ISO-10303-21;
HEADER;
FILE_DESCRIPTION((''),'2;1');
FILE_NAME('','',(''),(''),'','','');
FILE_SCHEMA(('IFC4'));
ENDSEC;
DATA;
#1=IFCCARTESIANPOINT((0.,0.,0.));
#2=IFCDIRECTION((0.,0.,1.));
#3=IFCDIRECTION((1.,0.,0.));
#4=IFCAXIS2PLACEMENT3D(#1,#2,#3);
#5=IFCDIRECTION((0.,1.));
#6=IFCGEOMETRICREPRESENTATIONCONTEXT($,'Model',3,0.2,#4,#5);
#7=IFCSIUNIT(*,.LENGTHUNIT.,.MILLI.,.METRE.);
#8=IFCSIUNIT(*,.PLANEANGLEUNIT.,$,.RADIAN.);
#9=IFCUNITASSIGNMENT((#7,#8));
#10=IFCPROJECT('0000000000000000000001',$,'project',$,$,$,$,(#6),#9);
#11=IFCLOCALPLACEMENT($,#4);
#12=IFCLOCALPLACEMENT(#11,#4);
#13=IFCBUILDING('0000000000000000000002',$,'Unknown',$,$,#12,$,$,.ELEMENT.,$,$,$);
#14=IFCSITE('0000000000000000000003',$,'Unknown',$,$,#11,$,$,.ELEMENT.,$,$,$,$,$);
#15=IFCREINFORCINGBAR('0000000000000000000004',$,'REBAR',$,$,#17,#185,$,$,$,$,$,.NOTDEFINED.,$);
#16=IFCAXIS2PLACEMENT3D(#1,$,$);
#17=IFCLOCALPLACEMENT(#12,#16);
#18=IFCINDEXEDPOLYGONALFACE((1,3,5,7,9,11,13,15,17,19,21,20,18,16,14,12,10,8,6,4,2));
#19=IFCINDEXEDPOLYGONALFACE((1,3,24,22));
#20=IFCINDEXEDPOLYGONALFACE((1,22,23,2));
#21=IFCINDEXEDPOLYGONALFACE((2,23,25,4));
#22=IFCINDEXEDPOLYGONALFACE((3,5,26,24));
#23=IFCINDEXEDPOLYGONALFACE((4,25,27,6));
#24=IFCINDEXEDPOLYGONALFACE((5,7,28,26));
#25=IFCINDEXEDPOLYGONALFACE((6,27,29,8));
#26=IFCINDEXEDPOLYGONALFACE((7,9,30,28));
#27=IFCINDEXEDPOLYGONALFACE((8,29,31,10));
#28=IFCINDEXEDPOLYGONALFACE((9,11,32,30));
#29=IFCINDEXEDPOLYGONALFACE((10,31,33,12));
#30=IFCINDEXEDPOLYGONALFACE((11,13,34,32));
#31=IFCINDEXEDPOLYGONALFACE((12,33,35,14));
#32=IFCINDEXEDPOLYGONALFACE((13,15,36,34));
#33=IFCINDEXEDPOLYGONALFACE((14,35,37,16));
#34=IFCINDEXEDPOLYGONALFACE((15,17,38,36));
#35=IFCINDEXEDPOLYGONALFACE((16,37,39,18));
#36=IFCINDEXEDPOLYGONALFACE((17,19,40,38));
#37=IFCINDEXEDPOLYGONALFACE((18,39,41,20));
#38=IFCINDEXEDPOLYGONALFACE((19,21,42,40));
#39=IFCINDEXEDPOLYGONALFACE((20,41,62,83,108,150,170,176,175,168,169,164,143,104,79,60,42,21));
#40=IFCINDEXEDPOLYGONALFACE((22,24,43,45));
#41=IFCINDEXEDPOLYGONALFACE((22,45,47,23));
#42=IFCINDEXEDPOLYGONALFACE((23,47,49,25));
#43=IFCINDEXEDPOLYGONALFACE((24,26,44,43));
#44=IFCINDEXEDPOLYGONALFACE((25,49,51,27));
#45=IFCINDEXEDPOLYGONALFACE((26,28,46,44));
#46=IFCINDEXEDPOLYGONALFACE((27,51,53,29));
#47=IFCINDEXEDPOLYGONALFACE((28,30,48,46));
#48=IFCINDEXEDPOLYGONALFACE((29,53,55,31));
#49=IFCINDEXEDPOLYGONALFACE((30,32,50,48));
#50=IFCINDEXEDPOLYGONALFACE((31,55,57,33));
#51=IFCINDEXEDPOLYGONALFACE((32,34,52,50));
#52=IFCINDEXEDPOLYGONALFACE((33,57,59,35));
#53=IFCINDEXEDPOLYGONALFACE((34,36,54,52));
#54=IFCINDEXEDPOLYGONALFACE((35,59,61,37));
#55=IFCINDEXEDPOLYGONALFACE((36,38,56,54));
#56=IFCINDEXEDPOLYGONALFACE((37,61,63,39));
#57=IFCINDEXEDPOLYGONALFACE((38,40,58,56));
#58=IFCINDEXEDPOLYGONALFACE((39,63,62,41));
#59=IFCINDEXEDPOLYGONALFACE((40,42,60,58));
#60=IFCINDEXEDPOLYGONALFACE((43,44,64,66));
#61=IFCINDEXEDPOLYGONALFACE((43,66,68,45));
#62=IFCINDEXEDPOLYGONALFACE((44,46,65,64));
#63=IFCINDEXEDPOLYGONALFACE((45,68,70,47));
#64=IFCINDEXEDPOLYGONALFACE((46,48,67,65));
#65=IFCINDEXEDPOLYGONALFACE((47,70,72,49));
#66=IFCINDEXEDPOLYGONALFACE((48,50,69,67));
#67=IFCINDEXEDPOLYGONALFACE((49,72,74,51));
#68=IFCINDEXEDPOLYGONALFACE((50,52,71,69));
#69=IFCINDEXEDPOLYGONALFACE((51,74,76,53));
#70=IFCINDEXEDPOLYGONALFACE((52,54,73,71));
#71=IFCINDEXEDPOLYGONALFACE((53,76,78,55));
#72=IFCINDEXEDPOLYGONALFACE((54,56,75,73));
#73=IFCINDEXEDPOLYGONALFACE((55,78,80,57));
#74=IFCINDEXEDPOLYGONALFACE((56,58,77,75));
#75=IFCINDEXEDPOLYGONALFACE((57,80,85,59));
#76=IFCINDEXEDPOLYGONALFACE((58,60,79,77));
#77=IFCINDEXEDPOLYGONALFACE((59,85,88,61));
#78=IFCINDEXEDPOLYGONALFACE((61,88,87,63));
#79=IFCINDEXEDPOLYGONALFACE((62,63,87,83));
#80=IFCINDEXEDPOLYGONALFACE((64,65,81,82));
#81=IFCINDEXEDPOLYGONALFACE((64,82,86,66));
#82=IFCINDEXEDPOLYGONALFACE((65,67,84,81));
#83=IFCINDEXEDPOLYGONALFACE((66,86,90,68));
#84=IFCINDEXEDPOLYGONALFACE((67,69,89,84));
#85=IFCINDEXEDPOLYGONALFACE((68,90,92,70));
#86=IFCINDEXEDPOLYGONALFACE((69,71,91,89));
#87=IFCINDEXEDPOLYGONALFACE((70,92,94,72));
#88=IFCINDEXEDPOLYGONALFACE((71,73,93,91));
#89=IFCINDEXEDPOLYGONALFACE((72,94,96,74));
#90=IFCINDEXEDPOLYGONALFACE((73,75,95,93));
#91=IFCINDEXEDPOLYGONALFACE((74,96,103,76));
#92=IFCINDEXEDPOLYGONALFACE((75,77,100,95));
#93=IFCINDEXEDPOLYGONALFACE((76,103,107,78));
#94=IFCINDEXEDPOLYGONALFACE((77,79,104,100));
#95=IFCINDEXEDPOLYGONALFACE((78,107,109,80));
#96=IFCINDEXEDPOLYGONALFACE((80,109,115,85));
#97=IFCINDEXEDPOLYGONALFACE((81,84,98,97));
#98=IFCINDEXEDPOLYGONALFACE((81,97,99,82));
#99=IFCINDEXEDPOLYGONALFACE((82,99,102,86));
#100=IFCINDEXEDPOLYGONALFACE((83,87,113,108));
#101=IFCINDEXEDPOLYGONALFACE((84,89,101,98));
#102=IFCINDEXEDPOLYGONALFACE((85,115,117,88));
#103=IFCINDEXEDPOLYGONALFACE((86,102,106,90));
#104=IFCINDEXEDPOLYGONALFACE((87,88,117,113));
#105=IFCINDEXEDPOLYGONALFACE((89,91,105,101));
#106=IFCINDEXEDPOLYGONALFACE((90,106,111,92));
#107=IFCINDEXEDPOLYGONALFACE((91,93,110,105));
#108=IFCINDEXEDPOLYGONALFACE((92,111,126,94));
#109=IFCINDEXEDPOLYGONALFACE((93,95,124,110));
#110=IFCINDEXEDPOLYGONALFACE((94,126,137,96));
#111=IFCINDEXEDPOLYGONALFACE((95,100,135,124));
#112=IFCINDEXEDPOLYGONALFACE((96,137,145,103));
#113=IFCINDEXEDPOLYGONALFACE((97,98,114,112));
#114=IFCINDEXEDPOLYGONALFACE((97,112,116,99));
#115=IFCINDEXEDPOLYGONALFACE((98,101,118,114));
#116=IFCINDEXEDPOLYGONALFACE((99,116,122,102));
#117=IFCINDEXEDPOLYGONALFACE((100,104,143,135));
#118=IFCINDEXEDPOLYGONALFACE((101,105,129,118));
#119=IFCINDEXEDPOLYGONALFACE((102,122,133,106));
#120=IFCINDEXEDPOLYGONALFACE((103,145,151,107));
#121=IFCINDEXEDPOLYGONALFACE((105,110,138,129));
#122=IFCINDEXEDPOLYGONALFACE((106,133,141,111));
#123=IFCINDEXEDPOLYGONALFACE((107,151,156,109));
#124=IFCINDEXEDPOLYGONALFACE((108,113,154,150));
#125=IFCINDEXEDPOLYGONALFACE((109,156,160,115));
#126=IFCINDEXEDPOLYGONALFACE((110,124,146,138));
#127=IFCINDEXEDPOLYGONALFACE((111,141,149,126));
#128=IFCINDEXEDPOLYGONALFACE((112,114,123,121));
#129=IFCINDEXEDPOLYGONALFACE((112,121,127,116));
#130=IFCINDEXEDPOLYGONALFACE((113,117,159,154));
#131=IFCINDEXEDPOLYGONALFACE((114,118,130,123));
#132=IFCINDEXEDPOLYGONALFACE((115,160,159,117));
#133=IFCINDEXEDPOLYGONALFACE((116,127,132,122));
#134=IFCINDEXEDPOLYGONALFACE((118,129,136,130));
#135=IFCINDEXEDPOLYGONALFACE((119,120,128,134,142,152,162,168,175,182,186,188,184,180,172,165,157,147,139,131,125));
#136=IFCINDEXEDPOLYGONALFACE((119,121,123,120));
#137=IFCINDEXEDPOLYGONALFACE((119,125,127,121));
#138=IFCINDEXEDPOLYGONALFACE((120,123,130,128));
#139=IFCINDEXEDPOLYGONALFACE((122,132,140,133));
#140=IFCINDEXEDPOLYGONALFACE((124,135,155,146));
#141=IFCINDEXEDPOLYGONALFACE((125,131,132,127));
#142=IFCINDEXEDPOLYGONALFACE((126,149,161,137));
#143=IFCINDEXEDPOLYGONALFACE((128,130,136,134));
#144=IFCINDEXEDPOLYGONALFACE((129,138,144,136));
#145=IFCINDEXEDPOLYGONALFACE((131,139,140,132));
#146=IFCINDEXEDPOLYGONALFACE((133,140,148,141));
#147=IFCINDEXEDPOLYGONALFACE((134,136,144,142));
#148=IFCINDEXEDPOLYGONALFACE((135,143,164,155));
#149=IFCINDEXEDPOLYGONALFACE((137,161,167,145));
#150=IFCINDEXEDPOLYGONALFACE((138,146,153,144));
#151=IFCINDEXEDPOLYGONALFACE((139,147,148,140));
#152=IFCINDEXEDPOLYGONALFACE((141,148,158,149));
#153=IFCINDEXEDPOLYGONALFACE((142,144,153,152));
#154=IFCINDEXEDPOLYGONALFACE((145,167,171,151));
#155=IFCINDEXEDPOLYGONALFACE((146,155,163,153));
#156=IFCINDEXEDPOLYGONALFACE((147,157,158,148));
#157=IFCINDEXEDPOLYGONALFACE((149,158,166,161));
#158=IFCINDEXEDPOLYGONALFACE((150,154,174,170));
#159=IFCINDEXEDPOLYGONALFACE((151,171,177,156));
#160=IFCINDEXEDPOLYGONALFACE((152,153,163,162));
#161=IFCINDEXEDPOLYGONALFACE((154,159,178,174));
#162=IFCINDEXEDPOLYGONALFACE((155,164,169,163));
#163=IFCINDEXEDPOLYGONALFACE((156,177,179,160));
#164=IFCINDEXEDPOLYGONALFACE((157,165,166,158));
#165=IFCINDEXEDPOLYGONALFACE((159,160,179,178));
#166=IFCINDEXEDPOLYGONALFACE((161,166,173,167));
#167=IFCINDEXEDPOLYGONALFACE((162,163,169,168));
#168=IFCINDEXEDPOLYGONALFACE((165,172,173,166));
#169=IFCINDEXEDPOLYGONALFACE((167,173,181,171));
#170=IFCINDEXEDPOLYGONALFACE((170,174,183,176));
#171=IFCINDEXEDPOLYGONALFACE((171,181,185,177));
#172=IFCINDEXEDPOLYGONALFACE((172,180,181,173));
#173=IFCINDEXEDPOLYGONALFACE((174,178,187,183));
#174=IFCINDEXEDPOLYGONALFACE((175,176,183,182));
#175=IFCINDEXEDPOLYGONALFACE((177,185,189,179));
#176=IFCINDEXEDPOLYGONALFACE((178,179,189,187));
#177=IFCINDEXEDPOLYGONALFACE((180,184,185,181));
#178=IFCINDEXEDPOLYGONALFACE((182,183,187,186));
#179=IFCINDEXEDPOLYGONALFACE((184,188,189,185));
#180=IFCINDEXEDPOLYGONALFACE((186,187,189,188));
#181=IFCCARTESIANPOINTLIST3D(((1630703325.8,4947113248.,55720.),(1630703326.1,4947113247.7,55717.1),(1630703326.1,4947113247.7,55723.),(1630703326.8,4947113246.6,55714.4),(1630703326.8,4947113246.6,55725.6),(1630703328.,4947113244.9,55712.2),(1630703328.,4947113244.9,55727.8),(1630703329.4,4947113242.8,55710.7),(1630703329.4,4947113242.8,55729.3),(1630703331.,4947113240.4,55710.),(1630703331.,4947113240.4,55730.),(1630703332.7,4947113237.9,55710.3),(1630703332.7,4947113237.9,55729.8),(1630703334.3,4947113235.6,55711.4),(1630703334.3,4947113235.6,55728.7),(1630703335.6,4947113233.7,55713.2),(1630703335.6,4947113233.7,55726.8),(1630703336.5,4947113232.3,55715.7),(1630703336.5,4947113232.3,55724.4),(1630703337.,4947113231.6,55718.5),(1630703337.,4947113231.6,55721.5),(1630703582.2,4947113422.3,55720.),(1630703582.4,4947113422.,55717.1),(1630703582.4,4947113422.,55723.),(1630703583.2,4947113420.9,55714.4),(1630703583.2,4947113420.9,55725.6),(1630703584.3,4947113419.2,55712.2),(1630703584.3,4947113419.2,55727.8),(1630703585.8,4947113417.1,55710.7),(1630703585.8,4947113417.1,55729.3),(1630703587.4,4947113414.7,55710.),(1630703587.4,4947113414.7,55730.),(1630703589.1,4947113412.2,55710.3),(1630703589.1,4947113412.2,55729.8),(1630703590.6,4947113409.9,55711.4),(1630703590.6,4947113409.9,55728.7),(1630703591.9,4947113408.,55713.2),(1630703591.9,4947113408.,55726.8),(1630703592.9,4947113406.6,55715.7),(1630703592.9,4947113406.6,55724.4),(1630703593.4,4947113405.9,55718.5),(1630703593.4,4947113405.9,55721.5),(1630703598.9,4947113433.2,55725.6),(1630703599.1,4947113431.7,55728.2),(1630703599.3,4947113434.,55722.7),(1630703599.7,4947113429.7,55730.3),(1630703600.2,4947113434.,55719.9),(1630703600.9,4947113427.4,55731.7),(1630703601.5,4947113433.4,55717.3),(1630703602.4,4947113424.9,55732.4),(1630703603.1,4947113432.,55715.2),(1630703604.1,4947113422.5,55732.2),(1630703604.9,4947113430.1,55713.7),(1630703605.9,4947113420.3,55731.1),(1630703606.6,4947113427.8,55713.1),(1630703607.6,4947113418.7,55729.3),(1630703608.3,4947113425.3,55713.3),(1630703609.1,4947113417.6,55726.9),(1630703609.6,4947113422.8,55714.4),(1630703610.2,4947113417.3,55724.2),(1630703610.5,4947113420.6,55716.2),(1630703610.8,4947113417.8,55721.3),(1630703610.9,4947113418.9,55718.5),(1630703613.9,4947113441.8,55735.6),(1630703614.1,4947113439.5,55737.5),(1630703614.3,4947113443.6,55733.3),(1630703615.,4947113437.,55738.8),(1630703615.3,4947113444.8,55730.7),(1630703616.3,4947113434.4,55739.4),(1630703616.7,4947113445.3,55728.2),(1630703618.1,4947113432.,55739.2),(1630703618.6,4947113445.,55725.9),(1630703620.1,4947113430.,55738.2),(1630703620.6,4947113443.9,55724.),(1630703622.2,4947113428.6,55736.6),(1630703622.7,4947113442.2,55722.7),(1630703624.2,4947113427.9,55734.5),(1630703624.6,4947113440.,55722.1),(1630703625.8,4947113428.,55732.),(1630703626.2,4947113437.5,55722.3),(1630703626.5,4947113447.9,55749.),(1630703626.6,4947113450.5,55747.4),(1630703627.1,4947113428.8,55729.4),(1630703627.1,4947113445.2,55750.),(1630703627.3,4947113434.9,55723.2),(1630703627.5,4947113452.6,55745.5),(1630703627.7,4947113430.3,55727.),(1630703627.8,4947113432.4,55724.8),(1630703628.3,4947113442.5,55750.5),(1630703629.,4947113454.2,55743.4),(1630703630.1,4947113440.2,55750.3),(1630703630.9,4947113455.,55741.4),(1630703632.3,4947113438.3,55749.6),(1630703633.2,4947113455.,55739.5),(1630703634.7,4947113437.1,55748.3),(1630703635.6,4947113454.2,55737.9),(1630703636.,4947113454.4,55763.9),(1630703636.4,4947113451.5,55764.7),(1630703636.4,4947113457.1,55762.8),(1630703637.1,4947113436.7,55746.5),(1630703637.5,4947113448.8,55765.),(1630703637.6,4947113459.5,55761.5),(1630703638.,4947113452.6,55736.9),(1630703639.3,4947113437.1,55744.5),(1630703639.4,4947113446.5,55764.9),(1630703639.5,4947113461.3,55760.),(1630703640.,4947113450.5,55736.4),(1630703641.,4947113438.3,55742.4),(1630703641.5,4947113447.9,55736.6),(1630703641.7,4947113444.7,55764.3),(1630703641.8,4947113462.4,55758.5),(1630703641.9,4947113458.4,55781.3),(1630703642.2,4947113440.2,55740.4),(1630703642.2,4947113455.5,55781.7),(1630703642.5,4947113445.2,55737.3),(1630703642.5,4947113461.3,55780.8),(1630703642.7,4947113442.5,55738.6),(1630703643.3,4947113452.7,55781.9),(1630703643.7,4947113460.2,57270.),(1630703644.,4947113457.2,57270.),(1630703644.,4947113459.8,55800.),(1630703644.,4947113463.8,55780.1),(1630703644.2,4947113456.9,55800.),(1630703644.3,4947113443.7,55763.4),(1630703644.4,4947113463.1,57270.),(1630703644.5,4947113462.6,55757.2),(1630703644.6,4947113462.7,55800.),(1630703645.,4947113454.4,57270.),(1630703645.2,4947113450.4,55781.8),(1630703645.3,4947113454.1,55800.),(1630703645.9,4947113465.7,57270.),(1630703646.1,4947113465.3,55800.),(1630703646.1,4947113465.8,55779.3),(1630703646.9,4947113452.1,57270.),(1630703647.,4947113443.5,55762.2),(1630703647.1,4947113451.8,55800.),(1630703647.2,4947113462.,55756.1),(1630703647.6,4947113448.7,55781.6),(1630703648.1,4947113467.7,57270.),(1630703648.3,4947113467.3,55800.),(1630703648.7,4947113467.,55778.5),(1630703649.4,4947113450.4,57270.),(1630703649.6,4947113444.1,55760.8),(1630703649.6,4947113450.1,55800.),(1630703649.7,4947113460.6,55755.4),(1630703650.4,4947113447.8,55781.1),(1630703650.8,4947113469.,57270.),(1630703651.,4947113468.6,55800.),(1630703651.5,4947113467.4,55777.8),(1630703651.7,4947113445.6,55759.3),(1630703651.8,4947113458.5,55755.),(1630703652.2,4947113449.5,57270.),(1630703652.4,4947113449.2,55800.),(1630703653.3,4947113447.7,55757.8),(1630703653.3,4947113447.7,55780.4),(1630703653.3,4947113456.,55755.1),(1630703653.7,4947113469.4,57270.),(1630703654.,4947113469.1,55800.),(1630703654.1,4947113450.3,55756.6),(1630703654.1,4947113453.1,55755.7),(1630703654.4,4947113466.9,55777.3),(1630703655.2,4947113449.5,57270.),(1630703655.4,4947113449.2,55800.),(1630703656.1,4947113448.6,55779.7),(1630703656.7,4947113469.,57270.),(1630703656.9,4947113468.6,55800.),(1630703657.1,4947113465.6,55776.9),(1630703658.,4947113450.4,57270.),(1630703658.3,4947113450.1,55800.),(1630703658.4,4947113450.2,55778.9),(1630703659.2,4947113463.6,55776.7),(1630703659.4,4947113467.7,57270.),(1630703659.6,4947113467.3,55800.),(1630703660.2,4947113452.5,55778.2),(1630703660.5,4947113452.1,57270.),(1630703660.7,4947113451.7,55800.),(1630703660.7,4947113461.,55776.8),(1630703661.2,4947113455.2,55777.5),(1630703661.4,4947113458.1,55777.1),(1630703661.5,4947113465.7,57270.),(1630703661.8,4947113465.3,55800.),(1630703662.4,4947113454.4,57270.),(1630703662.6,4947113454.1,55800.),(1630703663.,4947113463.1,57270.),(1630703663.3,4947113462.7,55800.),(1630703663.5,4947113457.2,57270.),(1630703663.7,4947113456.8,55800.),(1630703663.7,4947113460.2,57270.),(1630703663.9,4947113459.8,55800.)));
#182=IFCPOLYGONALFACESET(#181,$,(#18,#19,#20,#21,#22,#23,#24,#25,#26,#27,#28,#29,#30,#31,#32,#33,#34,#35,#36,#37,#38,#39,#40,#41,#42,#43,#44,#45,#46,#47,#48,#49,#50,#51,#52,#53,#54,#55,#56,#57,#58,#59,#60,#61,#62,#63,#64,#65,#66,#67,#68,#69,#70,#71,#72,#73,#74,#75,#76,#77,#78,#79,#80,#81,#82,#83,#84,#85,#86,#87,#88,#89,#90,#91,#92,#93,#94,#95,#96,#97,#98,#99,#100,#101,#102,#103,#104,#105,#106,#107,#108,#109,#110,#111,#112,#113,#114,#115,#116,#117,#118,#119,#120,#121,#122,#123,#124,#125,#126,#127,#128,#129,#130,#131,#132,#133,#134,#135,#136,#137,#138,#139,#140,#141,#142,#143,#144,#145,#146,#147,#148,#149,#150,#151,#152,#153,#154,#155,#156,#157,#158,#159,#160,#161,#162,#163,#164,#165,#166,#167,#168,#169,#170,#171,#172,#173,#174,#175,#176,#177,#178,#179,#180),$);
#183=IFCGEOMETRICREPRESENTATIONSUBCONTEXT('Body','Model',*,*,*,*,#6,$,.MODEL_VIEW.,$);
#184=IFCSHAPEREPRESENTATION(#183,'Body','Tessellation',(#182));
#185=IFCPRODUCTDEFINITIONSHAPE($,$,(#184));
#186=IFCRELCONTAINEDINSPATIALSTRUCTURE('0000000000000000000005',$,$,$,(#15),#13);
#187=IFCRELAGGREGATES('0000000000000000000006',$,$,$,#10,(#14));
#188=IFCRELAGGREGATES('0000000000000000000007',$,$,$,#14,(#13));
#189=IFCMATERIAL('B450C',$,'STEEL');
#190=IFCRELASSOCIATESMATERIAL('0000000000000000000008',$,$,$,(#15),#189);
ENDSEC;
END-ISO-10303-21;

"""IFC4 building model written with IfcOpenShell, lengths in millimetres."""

from ifc_helpers import new_model, entity, si_unit, direction, frame, origin_with_axes, place, context, subcontext, project, spatial, material, element, save


model = new_model("IFC4")

# Units and contexts
model_context = context("Model", 3, precision=0.2, world=origin_with_axes(), true_north=direction((0.0, 1.0)))
body_context = subcontext(model_context, "Body", "Model", "MODEL_VIEW")
ifc_project = project(units=[si_unit("LENGTHUNIT", "METRE", prefix="MILLI"), si_unit("PLANEANGLEUNIT", "RADIAN")], contexts=[model_context])

# Site, building
site_placement = place(None, origin_with_axes())
site = spatial("IfcSite", under=ifc_project, at=site_placement, Name="Unknown", CompositionType="ELEMENT")
building_placement = place(site_placement, origin_with_axes())
building = spatial("IfcBuilding", under=site, at=building_placement, Name="Unknown", CompositionType="ELEMENT")

# Reinforcing bar
ifc_material = material(Name="B450C", Category="STEEL")
reinforcing_bar_1_placement = place(building_placement, frame((1630703667.2, 4947113528.5, 55670.0), z_axis=(0.562329, -0.826914, 0.0), x_axis=(0.0, 0.0, 1.0)))
element("IfcReinforcingBar", 1, at=reinforcing_bar_1_placement, inside=building, material=ifc_material, Name="REBAR", PredefinedType="NOTDEFINED", context=body_context, shape_type="AdvancedSweptSolid", body=[
    entity("IfcSweptDiskSolid", entity("IfcIndexedPolyCurve", entity("IfcCartesianPointList3D", [[50.0, 440.0, 50.0], [50.0, 130.0, 50.0], [73.4, 73.4, 50.0], [130.0, 50.0, 50.0], [1600.0, 50.0, 49.5]]), [entity("IfcLineIndex", [1, 2]), entity("IfcArcIndex", [2, 3, 4]), entity("IfcLineIndex", [4, 5])]), 10.0),
])

save(model, "model.ifc")
